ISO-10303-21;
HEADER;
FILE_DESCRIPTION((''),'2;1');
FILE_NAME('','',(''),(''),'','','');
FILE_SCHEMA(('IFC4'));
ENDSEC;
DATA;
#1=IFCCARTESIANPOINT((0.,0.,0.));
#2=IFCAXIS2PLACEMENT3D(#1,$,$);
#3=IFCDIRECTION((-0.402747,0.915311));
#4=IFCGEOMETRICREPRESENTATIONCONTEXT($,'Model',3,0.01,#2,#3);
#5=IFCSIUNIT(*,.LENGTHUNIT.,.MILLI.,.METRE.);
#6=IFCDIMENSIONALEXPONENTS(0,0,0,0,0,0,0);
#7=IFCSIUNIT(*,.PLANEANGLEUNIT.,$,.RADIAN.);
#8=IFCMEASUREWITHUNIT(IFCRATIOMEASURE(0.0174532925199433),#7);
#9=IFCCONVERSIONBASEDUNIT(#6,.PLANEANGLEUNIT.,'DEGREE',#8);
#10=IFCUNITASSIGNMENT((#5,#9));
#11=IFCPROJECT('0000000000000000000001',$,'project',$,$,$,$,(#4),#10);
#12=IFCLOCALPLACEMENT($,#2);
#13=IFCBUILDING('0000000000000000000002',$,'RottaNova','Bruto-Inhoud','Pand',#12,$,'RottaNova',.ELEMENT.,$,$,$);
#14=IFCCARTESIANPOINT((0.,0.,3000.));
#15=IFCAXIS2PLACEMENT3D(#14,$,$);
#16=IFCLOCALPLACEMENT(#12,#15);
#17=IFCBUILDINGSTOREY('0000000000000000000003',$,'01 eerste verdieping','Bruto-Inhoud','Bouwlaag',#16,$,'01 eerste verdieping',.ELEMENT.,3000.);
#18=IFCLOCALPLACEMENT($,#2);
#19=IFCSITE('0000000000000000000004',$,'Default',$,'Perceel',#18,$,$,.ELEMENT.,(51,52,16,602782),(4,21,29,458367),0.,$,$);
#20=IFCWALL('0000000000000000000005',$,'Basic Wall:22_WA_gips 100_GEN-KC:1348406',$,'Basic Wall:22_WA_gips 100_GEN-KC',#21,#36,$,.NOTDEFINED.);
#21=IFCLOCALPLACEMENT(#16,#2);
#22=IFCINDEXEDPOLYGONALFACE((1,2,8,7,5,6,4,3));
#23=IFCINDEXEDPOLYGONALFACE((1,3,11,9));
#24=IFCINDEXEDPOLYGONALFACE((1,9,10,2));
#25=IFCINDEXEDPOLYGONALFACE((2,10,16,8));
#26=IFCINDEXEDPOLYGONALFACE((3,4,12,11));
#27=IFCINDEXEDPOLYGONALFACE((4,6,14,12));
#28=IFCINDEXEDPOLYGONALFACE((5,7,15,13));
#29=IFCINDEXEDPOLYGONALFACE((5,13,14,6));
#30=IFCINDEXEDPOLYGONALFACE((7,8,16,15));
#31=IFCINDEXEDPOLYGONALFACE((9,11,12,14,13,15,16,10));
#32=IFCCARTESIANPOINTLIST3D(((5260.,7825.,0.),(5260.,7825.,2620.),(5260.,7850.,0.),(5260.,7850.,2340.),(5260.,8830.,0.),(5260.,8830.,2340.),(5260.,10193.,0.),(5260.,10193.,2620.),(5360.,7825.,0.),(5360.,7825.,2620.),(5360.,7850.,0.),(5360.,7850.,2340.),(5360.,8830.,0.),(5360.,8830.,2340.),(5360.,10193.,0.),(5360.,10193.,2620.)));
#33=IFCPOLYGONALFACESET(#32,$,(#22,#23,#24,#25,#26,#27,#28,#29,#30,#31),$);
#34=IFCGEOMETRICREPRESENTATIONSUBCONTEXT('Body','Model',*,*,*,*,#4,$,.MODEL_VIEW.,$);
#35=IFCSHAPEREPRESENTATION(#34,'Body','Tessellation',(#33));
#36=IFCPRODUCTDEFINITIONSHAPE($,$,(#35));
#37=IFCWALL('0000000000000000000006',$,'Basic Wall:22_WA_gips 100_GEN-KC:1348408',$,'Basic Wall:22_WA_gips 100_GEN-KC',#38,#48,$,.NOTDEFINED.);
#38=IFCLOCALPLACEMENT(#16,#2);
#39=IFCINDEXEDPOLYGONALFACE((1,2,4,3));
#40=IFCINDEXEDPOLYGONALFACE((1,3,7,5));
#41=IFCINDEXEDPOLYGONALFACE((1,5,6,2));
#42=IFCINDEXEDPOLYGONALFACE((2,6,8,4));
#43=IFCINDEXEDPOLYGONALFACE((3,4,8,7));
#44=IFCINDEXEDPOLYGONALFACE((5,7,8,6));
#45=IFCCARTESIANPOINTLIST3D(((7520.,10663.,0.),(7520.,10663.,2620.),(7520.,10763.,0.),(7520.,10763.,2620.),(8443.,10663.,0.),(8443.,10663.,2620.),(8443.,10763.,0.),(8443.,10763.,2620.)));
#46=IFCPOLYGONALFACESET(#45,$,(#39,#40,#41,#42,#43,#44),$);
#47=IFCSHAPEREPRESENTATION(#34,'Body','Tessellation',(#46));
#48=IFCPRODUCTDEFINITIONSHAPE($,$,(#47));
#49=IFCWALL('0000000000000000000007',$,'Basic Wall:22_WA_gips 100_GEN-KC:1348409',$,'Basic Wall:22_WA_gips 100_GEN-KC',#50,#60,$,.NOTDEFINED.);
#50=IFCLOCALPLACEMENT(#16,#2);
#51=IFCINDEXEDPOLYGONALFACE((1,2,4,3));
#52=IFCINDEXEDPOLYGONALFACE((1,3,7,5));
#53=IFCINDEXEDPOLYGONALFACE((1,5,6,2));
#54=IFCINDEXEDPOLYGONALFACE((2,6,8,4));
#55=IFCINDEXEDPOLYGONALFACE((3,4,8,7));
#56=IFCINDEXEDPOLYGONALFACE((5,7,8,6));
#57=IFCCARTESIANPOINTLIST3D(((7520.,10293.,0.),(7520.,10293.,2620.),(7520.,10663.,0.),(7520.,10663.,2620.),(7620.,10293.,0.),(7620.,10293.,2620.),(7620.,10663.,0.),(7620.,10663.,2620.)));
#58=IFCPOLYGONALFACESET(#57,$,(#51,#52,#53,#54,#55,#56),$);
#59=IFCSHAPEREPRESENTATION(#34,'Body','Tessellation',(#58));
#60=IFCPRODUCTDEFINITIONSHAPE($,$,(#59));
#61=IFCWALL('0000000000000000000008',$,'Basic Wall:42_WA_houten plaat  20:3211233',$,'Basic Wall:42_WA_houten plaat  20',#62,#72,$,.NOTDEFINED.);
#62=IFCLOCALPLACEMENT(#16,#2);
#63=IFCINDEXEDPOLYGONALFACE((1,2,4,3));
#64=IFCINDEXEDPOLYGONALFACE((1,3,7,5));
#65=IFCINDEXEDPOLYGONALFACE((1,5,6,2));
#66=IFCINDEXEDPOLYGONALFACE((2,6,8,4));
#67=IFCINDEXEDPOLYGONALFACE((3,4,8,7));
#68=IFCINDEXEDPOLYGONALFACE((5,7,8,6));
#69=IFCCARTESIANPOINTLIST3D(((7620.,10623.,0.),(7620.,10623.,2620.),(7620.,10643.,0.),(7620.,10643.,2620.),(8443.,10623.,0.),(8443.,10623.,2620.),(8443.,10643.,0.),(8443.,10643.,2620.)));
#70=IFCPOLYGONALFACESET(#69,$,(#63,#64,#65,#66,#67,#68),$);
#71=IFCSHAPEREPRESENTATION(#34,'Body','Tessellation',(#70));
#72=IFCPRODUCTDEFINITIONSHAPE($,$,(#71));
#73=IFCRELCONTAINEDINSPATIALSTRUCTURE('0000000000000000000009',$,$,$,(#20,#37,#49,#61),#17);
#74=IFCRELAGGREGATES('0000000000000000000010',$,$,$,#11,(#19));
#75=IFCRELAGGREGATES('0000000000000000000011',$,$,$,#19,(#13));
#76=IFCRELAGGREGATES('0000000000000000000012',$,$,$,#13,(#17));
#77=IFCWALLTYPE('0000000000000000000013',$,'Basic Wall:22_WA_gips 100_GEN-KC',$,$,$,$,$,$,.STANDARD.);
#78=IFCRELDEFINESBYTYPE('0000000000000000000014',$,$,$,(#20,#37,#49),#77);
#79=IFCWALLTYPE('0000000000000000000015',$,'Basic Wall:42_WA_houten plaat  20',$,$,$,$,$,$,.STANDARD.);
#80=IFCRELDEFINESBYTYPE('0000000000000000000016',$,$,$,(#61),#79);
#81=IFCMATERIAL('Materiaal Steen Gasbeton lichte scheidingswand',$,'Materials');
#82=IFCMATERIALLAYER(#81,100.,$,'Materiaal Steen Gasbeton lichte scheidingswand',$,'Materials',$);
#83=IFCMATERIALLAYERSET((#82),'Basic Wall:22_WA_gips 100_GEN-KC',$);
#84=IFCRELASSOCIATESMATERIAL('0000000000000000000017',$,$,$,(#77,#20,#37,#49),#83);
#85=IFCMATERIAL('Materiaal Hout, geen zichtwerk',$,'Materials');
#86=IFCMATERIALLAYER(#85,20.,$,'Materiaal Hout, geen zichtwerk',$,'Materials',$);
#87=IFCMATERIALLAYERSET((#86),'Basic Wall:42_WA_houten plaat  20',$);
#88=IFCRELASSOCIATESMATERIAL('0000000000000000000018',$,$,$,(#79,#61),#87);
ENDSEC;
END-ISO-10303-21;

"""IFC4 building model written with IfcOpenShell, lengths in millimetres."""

from ifc_helpers import new_model, entity, si_unit, converted_unit, direction, frame, frame_2d, origin, place, context, subcontext, project, spatial, rectangle, extrude, material, layer, layer_set, type_object, element, save


model = new_model("IFC4")

# Units and contexts
model_context = context("Model", 3, precision=0.01, world=origin(), true_north=direction((-0.402747, 0.915311)))
body_context = subcontext(model_context, "Body", "Model", "MODEL_VIEW")
ifc_project = project(units=[si_unit("LENGTHUNIT", "METRE", prefix="MILLI"), converted_unit("PLANEANGLEUNIT", "DEGREE", entity("IfcRatioMeasure", 0.0174532925199433), si_unit("PLANEANGLEUNIT", "RADIAN"), dimensions=[0, 0, 0, 0, 0, 0, 0])], contexts=[model_context])

# Site, building, storey
site_placement = place(None, origin())
site = spatial("IfcSite", under=ifc_project, at=site_placement, Name="Default", ObjectType="Perceel", CompositionType="ELEMENT", RefLatitude=(51, 52, 16, 602782), RefLongitude=(4, 21, 29, 458367), RefElevation=0.0)
building_placement = place(None, origin())
building = spatial("IfcBuilding", under=site, at=building_placement, Name="RottaNova", Description="Bruto-Inhoud", ObjectType="Pand", LongName="RottaNova", CompositionType="ELEMENT")
storey_placement = place(building_placement, frame((0.0, 0.0, 3000.0)))
storey = spatial("IfcBuildingStorey", under=building, at=storey_placement, Name="01 eerste verdieping", Description="Bruto-Inhoud", ObjectType="Bouwlaag", LongName="01 eerste verdieping", CompositionType="ELEMENT", Elevation=3000.0)

# Wall, opening
ifc_material_1 = material(Name="Materiaal Steen Gasbeton lichte scheidingswand", Category="Materials")
ifc_layer_1 = layer(ifc_material_1, 100.0, Name="Materiaal Steen Gasbeton lichte scheidingswand", Category="Materials")
ifc_layer_set_1 = layer_set([ifc_layer_1], Name="Basic Wall:22_WA_gips 100_GEN-KC")
wall_type_1 = type_object("IfcWallType", Name="Basic Wall:22_WA_gips 100_GEN-KC", PredefinedType="STANDARD", material=ifc_layer_set_1)
wall_1_placement = place(storey_placement, frame((5310.0, 10193.0, 0.0), z_axis=(0.0, 0.0, 1.0), x_axis=(0.0, -1.0, 0.0)))
wall_1 = element("IfcWall", 1, at=wall_1_placement, inside=storey, type_object=wall_type_1, material=ifc_layer_set_1, Name="Basic Wall:22_WA_gips 100_GEN-KC:1348406", ObjectType="Basic Wall:22_WA_gips 100_GEN-KC", PredefinedType="NOTDEFINED", context=body_context, shape_type="SweptSolid", body=[
    extrude(rectangle(XDim=2368.0, YDim=100.0, at=frame_2d((1184.0, 0.0), x_axis=(1.0, 0.0))), origin(), (0.0, 0.0, 1.0), 2620.0),
])
opening_1_placement = place(wall_1_placement, frame((2343.0, 50.0, -90.0)))
element("IfcOpeningElement", 2, at=opening_1_placement, cuts=wall_1, PredefinedType="OPENING", context=body_context, shape_type="SweptSolid", body=[
    extrude(rectangle(XDim=2430.0, YDim=980.0, at=frame_2d((1215.0, 490.0), x_axis=(1.0, 0.0))), frame((0.0, 0.0, 0.0), z_axis=(0.0, -1.0, 0.0), x_axis=(0.0, 0.0, 1.0)), (0.0, 0.0, 1.0), 100.0),
])

# Walls
wall_2_placement = place(storey_placement, frame((7520.0, 10713.0, 0.0)))
element("IfcWall", 3, at=wall_2_placement, inside=storey, type_object=wall_type_1, material=ifc_layer_set_1, Name="Basic Wall:22_WA_gips 100_GEN-KC:1348408", ObjectType="Basic Wall:22_WA_gips 100_GEN-KC", PredefinedType="NOTDEFINED", context=body_context, shape_type="SweptSolid", body=[
    extrude(rectangle(XDim=923.0, YDim=100.0, at=frame_2d((461.5, 0.0), x_axis=(-1.0, 0.0))), origin(), (0.0, 0.0, 1.0), 2620.0),
])
wall_3_placement = place(storey_placement, frame((7570.0, 10663.0, 0.0), z_axis=(0.0, 0.0, 1.0), x_axis=(0.0, -1.0, 0.0)))
element("IfcWall", 4, at=wall_3_placement, inside=storey, type_object=wall_type_1, material=ifc_layer_set_1, Name="Basic Wall:22_WA_gips 100_GEN-KC:1348409", ObjectType="Basic Wall:22_WA_gips 100_GEN-KC", PredefinedType="NOTDEFINED", context=body_context, shape_type="SweptSolid", body=[
    extrude(rectangle(XDim=370.0, YDim=100.0, at=frame_2d((185.0, 0.0), x_axis=(-1.0, 0.0))), origin(), (0.0, 0.0, 1.0), 2620.0),
])
ifc_material_2 = material(Name="Materiaal Hout, geen zichtwerk", Category="Materials")
ifc_layer_2 = layer(ifc_material_2, 20.0, Name="Materiaal Hout, geen zichtwerk", Category="Materials")
ifc_layer_set_2 = layer_set([ifc_layer_2], Name="Basic Wall:42_WA_houten plaat  20")
wall_type_2 = type_object("IfcWallType", Name="Basic Wall:42_WA_houten plaat  20", PredefinedType="STANDARD", material=ifc_layer_set_2)
wall_4_placement = place(storey_placement, frame((7620.0, 10633.0, 0.0)))
element("IfcWall", 5, at=wall_4_placement, inside=storey, type_object=wall_type_2, material=ifc_layer_set_2, Name="Basic Wall:42_WA_houten plaat  20:3211233", ObjectType="Basic Wall:42_WA_houten plaat  20", PredefinedType="NOTDEFINED", context=body_context, shape_type="SweptSolid", body=[
    extrude(rectangle(XDim=823.0, YDim=20.0, at=frame_2d((411.5, 0.0), x_axis=(-1.0, 0.0))), origin(), (0.0, 0.0, 1.0), 2620.0),
])

save(model, "model.ifc")
